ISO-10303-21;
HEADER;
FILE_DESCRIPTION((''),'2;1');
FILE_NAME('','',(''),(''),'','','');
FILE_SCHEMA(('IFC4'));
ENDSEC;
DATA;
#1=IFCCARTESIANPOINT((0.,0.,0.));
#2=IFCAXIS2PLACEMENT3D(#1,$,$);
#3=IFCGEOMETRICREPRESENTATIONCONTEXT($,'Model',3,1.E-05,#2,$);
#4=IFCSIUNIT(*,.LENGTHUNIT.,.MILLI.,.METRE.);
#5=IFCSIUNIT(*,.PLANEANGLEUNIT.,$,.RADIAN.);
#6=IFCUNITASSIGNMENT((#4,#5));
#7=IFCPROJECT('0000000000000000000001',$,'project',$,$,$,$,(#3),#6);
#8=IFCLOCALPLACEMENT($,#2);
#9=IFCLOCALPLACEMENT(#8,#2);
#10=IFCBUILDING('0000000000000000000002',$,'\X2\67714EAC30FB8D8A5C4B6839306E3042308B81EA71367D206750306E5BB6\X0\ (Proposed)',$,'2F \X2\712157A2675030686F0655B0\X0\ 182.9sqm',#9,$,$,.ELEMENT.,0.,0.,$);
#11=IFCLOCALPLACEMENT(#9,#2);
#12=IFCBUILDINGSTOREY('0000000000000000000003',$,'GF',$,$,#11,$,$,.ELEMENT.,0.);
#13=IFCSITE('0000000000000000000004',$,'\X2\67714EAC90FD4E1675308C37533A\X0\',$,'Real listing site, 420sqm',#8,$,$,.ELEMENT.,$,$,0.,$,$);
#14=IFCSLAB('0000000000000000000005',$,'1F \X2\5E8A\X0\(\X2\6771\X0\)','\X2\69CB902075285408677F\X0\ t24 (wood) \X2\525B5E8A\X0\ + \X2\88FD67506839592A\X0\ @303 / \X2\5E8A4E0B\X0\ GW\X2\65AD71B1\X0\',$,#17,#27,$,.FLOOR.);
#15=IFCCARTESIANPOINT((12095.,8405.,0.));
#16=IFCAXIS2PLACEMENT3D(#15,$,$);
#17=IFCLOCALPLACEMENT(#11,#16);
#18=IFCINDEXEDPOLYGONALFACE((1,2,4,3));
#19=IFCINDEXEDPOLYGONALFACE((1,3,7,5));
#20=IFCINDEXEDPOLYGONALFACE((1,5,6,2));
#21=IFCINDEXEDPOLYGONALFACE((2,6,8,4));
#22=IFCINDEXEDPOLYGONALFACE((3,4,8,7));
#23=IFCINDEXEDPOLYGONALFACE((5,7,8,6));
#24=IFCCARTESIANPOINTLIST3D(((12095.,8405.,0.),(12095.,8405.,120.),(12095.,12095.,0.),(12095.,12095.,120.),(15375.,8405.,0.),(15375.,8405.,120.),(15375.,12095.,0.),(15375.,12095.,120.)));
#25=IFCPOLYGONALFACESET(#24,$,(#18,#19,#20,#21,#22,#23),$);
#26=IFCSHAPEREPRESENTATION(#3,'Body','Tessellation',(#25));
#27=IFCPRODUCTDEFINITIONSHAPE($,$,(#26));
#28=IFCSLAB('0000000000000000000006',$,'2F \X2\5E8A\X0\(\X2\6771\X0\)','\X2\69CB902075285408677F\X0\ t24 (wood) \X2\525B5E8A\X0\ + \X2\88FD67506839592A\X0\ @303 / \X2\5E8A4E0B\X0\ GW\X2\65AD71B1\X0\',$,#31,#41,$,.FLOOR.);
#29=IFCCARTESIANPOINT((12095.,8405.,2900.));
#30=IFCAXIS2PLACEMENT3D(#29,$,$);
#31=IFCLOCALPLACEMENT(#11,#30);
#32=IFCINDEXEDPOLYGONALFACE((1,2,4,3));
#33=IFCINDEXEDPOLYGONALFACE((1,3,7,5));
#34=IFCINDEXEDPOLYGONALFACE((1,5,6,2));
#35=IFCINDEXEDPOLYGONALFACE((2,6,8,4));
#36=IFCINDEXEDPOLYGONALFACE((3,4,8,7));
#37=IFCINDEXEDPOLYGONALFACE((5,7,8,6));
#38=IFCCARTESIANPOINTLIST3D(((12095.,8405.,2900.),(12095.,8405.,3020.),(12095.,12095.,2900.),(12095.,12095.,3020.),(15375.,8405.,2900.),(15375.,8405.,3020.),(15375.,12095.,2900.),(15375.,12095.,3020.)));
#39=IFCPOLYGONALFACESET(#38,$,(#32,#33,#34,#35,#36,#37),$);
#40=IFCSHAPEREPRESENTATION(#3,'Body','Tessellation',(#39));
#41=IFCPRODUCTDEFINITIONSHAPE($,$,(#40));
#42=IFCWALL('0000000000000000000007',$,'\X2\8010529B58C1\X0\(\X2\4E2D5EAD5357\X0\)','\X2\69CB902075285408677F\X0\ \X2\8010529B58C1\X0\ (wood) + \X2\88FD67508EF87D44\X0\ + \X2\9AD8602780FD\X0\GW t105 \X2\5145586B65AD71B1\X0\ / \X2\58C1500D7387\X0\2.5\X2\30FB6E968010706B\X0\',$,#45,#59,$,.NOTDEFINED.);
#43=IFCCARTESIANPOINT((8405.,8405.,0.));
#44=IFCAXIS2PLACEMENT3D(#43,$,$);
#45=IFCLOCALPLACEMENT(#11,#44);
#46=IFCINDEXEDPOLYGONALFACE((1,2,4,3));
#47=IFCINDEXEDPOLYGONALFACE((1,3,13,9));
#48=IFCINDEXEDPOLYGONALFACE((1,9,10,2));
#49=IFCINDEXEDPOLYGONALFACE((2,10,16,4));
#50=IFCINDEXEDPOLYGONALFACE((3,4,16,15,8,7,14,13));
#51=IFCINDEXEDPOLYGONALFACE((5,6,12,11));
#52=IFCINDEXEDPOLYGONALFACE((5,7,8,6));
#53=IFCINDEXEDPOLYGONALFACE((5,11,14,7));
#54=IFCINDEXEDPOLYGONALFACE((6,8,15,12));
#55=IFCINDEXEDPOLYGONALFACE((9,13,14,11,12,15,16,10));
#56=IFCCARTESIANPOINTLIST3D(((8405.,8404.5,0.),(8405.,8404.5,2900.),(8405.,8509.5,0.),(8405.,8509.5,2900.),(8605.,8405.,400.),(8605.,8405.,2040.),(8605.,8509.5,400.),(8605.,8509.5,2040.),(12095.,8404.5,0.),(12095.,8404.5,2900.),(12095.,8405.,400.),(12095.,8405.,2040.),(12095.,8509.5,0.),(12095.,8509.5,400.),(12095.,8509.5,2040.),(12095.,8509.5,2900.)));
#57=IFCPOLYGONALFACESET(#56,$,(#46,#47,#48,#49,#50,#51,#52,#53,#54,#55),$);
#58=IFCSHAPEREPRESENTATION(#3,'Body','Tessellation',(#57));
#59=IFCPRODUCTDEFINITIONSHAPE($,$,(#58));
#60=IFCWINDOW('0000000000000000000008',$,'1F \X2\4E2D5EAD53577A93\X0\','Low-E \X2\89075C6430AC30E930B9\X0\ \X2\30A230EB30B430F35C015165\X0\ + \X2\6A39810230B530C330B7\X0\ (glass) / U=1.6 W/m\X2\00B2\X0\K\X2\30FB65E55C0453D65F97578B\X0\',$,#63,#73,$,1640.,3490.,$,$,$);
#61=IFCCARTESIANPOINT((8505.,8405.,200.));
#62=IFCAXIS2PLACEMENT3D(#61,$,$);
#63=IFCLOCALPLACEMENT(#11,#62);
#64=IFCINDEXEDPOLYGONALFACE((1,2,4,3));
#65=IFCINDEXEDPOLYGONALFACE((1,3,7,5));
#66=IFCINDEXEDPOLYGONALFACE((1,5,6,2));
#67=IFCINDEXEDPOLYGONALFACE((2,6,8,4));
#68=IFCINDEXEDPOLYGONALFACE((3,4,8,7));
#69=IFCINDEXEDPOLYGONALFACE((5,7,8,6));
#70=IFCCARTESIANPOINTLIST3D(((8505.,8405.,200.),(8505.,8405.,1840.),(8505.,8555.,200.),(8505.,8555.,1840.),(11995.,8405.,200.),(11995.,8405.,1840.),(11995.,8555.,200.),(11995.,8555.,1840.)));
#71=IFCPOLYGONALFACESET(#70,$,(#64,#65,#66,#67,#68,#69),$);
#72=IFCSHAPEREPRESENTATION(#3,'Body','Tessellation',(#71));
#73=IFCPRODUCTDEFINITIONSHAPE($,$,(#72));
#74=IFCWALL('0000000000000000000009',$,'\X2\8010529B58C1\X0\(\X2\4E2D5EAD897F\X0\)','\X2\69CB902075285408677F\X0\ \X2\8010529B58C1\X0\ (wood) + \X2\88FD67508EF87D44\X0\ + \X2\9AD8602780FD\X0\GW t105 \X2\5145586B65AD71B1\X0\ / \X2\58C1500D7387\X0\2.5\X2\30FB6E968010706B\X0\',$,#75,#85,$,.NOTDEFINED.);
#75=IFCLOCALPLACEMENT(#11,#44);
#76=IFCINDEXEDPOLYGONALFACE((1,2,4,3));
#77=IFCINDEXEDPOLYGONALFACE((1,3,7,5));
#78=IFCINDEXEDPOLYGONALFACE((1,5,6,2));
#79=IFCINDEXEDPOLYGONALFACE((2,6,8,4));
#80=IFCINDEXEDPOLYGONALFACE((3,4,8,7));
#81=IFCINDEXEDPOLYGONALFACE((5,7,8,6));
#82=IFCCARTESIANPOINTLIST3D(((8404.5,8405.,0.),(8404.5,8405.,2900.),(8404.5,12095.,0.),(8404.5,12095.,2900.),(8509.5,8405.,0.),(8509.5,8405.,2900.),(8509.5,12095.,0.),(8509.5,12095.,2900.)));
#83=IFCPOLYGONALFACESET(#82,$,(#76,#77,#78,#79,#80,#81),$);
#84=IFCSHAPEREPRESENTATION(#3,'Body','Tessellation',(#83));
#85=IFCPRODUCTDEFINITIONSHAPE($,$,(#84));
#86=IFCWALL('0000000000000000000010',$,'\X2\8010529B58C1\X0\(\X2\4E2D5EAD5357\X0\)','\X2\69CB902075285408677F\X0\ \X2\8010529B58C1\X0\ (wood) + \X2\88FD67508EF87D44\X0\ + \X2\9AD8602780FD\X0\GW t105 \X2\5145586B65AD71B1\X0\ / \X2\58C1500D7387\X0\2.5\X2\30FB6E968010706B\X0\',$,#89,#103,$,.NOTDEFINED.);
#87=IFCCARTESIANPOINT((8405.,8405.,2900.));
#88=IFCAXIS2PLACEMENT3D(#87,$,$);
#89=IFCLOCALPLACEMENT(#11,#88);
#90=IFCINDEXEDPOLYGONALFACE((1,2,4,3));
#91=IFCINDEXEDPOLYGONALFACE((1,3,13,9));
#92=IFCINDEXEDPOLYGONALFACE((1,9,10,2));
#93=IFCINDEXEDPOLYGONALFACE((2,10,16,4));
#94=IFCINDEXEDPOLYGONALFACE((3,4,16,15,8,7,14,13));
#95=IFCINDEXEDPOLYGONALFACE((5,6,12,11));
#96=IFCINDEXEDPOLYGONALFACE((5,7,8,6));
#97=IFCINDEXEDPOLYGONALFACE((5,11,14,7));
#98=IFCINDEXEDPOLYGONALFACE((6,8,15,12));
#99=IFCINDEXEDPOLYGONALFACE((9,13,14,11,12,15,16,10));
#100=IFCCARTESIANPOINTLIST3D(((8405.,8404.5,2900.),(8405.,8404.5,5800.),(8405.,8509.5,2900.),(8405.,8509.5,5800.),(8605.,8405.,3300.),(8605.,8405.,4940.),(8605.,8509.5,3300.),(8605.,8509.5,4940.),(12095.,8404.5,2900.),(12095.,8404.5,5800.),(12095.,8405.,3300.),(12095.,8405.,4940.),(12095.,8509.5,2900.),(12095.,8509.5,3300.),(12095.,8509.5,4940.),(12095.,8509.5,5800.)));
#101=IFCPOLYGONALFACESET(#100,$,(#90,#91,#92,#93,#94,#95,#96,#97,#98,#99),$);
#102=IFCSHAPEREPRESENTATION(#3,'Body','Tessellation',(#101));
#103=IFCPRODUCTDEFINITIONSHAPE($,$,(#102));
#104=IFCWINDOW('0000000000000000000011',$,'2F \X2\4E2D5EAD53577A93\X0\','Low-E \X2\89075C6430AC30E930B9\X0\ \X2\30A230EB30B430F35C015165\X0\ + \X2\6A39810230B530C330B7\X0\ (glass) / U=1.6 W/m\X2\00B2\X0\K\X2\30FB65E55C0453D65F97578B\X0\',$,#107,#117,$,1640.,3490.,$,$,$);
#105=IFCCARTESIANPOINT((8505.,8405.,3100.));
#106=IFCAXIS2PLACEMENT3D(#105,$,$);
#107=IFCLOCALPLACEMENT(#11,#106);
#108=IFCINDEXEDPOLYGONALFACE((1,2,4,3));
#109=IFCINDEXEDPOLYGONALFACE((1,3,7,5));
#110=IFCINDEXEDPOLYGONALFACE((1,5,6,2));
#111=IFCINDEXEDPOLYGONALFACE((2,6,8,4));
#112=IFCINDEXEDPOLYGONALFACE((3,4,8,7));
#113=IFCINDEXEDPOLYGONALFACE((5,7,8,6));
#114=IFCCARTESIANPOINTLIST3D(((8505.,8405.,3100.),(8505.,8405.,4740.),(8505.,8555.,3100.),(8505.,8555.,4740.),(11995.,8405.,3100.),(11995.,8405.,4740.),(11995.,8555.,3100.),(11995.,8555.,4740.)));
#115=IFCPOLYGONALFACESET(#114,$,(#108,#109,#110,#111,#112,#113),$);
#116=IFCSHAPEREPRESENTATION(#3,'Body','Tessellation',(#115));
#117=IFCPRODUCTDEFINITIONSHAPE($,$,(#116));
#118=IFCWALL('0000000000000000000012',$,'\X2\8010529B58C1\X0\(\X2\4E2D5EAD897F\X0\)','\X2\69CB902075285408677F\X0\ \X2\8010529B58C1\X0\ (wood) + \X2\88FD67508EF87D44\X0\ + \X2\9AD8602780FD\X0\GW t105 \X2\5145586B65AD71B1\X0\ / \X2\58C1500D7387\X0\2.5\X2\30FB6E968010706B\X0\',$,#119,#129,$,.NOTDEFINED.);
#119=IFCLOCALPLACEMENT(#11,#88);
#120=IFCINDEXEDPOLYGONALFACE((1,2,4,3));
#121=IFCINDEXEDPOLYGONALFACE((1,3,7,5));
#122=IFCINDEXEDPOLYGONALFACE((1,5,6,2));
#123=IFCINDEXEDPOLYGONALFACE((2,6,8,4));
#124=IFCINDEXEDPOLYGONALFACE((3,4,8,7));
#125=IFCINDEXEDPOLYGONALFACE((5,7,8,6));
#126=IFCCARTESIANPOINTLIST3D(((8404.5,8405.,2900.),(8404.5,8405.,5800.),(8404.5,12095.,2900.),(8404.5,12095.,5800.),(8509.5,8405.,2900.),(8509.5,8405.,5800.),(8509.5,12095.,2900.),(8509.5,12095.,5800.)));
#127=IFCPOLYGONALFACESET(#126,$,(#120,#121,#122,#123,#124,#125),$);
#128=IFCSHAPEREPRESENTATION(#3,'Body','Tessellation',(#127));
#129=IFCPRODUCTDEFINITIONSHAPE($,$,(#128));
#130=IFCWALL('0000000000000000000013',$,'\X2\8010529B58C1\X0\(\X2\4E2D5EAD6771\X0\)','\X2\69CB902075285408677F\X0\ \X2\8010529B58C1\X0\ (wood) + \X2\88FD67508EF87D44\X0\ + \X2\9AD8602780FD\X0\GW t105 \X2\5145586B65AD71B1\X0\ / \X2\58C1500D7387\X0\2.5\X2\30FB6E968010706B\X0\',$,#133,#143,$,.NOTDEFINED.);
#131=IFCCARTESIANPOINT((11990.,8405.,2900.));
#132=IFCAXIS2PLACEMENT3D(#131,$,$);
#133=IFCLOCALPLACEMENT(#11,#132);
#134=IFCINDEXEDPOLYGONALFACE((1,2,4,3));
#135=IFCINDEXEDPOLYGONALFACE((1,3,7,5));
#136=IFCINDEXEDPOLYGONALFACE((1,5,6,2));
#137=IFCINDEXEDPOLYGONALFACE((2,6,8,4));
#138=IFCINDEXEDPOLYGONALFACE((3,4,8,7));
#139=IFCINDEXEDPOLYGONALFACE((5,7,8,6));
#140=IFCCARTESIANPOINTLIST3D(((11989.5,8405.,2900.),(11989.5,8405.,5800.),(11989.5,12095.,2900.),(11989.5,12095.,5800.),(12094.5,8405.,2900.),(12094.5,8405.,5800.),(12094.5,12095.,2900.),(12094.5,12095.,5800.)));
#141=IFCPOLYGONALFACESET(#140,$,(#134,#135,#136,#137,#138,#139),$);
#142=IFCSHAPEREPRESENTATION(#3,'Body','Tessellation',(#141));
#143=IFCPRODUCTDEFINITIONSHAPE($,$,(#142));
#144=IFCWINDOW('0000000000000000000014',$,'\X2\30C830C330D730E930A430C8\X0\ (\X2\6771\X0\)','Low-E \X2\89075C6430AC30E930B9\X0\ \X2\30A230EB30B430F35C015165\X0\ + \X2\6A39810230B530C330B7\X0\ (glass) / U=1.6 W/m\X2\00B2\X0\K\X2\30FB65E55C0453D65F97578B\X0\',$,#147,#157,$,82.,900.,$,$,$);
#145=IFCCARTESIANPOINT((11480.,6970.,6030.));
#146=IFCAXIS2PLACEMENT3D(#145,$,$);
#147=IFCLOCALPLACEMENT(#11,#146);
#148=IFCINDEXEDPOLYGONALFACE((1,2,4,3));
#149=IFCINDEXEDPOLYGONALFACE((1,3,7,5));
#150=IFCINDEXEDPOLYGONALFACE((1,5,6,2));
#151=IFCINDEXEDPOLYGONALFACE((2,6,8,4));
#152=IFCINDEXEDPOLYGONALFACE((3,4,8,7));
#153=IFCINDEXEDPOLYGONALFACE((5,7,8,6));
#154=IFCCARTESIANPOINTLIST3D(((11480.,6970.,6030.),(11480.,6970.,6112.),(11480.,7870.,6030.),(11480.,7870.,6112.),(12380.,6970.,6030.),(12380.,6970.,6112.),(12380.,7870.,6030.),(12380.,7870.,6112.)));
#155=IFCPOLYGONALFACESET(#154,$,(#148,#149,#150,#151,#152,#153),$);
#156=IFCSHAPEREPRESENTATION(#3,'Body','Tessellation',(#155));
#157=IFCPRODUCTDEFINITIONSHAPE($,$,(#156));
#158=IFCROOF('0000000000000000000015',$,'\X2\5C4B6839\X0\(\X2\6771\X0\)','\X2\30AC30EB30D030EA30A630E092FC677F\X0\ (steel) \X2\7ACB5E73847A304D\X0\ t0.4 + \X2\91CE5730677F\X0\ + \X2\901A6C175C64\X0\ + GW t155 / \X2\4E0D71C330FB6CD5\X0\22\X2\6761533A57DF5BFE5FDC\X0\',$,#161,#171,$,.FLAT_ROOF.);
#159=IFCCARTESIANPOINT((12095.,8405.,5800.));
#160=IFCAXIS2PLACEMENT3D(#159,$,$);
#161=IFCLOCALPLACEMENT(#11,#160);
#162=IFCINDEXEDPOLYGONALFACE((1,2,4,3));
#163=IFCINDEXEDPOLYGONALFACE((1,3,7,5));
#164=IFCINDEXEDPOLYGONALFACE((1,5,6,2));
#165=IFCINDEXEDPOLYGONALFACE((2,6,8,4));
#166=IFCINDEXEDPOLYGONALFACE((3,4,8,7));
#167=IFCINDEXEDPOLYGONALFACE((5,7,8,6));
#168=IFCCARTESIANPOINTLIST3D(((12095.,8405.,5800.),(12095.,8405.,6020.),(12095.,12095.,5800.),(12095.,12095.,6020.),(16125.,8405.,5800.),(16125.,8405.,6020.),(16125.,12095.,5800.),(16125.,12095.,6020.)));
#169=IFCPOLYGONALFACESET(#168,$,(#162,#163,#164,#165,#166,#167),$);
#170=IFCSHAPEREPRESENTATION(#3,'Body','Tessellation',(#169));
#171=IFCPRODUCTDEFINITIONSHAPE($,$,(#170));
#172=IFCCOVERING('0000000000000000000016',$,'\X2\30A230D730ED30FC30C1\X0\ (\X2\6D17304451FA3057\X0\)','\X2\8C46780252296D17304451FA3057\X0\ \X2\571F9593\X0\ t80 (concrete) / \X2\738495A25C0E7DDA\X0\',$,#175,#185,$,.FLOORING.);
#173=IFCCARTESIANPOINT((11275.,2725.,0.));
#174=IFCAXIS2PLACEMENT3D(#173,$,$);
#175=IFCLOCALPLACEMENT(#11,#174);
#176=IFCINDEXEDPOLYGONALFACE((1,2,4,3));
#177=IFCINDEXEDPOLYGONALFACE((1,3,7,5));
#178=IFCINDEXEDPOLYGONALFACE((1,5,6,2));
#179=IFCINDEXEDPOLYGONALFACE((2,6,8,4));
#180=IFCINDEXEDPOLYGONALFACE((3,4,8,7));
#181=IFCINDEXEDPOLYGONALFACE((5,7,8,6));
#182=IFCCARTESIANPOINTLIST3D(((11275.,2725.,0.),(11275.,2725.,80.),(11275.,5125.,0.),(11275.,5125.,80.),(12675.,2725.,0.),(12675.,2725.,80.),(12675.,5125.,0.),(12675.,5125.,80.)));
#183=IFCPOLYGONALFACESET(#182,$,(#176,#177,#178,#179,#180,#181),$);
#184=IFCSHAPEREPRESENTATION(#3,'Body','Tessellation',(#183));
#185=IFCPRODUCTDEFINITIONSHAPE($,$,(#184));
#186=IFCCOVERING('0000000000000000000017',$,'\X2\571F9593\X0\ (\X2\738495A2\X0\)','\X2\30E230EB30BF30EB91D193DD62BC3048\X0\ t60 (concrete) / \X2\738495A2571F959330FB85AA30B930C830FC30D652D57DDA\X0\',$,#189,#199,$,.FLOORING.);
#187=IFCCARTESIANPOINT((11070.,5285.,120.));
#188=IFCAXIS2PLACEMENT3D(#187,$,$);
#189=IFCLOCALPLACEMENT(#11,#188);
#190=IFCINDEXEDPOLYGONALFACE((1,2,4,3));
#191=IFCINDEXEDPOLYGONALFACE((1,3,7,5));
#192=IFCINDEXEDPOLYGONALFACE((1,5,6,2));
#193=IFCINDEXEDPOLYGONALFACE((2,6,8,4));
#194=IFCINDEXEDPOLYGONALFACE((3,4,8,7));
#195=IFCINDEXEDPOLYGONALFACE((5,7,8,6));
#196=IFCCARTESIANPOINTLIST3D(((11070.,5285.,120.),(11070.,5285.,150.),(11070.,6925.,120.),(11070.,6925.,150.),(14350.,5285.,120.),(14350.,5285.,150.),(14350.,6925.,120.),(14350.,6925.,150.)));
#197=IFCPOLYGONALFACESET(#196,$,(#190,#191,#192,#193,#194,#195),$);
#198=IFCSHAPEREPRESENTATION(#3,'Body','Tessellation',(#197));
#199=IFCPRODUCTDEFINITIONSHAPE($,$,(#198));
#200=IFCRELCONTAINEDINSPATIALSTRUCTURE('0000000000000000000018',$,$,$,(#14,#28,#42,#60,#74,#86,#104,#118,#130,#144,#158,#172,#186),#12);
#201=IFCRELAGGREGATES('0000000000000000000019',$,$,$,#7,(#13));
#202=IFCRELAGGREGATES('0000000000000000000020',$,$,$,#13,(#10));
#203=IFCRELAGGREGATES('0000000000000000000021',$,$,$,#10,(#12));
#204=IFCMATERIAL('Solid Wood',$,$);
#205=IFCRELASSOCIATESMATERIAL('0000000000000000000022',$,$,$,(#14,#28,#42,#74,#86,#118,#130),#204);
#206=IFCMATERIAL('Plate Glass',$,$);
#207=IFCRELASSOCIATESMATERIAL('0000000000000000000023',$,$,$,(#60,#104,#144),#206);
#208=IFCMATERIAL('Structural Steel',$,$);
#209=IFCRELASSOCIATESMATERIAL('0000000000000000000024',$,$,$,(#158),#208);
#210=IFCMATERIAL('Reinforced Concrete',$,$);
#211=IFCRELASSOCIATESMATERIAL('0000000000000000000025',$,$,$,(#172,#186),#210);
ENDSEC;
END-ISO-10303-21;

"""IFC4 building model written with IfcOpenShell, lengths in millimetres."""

from ifc_helpers import new_model, si_unit, frame, frame_2d, origin, place, context, project, spatial, rectangle, extrude, material, element, fill, save


model = new_model("IFC4")

# Units and contexts
model_context = context("Model", 3, precision=1e-05, world=origin())
ifc_project = project(units=[si_unit("LENGTHUNIT", "METRE", prefix="MILLI"), si_unit("PLANEANGLEUNIT", "RADIAN")], contexts=[model_context])

# Site, building, storey
site_placement = place(None, origin())
site = spatial("IfcSite", under=ifc_project, at=site_placement, Name="東京都世田谷区", ObjectType="Real listing site, 420sqm", CompositionType="ELEMENT", RefElevation=0.0)
building_placement = place(site_placement, origin())
building = spatial("IfcBuilding", under=site, at=building_placement, Name="東京・越屋根のある自然素材の家 (Proposed)", ObjectType="2F 無垢材と漆喰 182.9sqm", CompositionType="ELEMENT", ElevationOfRefHeight=0.0, ElevationOfTerrain=0.0)
storey_placement = place(building_placement, origin())
storey = spatial("IfcBuildingStorey", under=building, at=storey_placement, Name="GF", CompositionType="ELEMENT", Elevation=0.0)

# Shared definitions
ifc_material_1 = material(Name="Solid Wood")

# Slabs
slab_1_placement = place(storey_placement, frame((12095.0, 8405.0, 0.0)))
element("IfcSlab", 1, at=slab_1_placement, inside=storey, material=ifc_material_1, Name="1F 床(東)", Description="構造用合板 t24 (wood) 剛床 + 製材根太 @303 / 床下 GW断熱", PredefinedType="FLOOR", context=model_context, shape_type="SweptSolid", body=[
    extrude(rectangle(XDim=3280.0, YDim=3690.0, at=frame_2d((1640.0, 1845.0))), frame((12095.0, 8405.0, 0.0)), (0.0, 0.0, 1.0), 120.0),
])
slab_2_placement = place(storey_placement, frame((12095.0, 8405.0, 2900.0)))
element("IfcSlab", 2, at=slab_2_placement, inside=storey, material=ifc_material_1, Name="2F 床(東)", Description="構造用合板 t24 (wood) 剛床 + 製材根太 @303 / 床下 GW断熱", PredefinedType="FLOOR", context=model_context, shape_type="SweptSolid", body=[
    extrude(rectangle(XDim=3280.0, YDim=3690.0, at=frame_2d((1640.0, 1845.0))), frame((12095.0, 8405.0, 2900.0)), (0.0, 0.0, 1.0), 120.0),
])

# Wall, opening, window
wall_1_placement = place(storey_placement, frame((8405.0, 8405.0, 0.0)))
wall_1 = element("IfcWall", 3, at=wall_1_placement, inside=storey, material=ifc_material_1, Name="耐力壁(中庭南)", Description="構造用合板 耐力壁 (wood) + 製材軸組 + 高性能GW t105 充填断熱 / 壁倍率2.5・準耐火", PredefinedType="NOTDEFINED", context=model_context, shape_type="SweptSolid", body=[
    extrude(rectangle(XDim=3690.0, YDim=105.0, at=frame_2d((1845.0, 52.0))), frame((8405.0, 8405.0, 0.0)), (0.0, 0.0, 1.0), 2900.0),
])
opening_1_placement = place(storey_placement, frame((8505.0, 8405.0, 200.0)))
opening_1 = element("IfcOpeningElement", 4, at=opening_1_placement, cuts=wall_1, PredefinedType="NOTDEFINED", context=model_context, shape_type="SweptSolid", body=[
    extrude(rectangle(XDim=3490.0, YDim=150.0, at=frame_2d((1745.0, 75.0))), frame((8505.0, 8405.0, 200.0)), (0.0, 0.0, 1.0), 1640.0),
])
ifc_material_2 = material(Name="Plate Glass")
window_1_placement = place(storey_placement, frame((8505.0, 8405.0, 200.0)))
window_1 = element("IfcWindow", 5, at=window_1_placement, inside=storey, material=ifc_material_2, Name="1F 中庭南窓", Description="Low-E 複層ガラス アルゴン封入 + 樹脂サッシ (glass) / U=1.6 W/m²K・日射取得型", OverallHeight=1640.0, OverallWidth=3490.0, context=model_context, shape_type="SweptSolid", body=[
    extrude(rectangle(XDim=3490.0, YDim=150.0, at=frame_2d((1745.0, 75.0))), frame((8505.0, 8405.0, 200.0)), (0.0, 0.0, 1.0), 1640.0),
])
fill(opening_1, window_1)

# Wall
wall_2_placement = place(storey_placement, frame((8405.0, 8405.0, 0.0)))
element("IfcWall", 6, at=wall_2_placement, inside=storey, material=ifc_material_1, Name="耐力壁(中庭西)", Description="構造用合板 耐力壁 (wood) + 製材軸組 + 高性能GW t105 充填断熱 / 壁倍率2.5・準耐火", PredefinedType="NOTDEFINED", context=model_context, shape_type="SweptSolid", body=[
    extrude(rectangle(XDim=105.0, YDim=3690.0, at=frame_2d((52.0, 1845.0))), frame((8405.0, 8405.0, 0.0)), (0.0, 0.0, 1.0), 2900.0),
])

# Wall, opening, window
wall_3_placement = place(storey_placement, frame((8405.0, 8405.0, 2900.0)))
wall_3 = element("IfcWall", 7, at=wall_3_placement, inside=storey, material=ifc_material_1, Name="耐力壁(中庭南)", Description="構造用合板 耐力壁 (wood) + 製材軸組 + 高性能GW t105 充填断熱 / 壁倍率2.5・準耐火", PredefinedType="NOTDEFINED", context=model_context, shape_type="SweptSolid", body=[
    extrude(rectangle(XDim=3690.0, YDim=105.0, at=frame_2d((1845.0, 52.0))), frame((8405.0, 8405.0, 2900.0)), (0.0, 0.0, 1.0), 2900.0),
])
opening_2_placement = place(storey_placement, frame((8505.0, 8405.0, 3100.0)))
opening_2 = element("IfcOpeningElement", 8, at=opening_2_placement, cuts=wall_3, PredefinedType="NOTDEFINED", context=model_context, shape_type="SweptSolid", body=[
    extrude(rectangle(XDim=3490.0, YDim=150.0, at=frame_2d((1745.0, 75.0))), frame((8505.0, 8405.0, 3100.0)), (0.0, 0.0, 1.0), 1640.0),
])
window_2_placement = place(storey_placement, frame((8505.0, 8405.0, 3100.0)))
window_2 = element("IfcWindow", 9, at=window_2_placement, inside=storey, material=ifc_material_2, Name="2F 中庭南窓", Description="Low-E 複層ガラス アルゴン封入 + 樹脂サッシ (glass) / U=1.6 W/m²K・日射取得型", OverallHeight=1640.0, OverallWidth=3490.0, context=model_context, shape_type="SweptSolid", body=[
    extrude(rectangle(XDim=3490.0, YDim=150.0, at=frame_2d((1745.0, 75.0))), frame((8505.0, 8405.0, 3100.0)), (0.0, 0.0, 1.0), 1640.0),
])
fill(opening_2, window_2)

# Walls
wall_4_placement = place(storey_placement, frame((8405.0, 8405.0, 2900.0)))
element("IfcWall", 10, at=wall_4_placement, inside=storey, material=ifc_material_1, Name="耐力壁(中庭西)", Description="構造用合板 耐力壁 (wood) + 製材軸組 + 高性能GW t105 充填断熱 / 壁倍率2.5・準耐火", PredefinedType="NOTDEFINED", context=model_context, shape_type="SweptSolid", body=[
    extrude(rectangle(XDim=105.0, YDim=3690.0, at=frame_2d((52.0, 1845.0))), frame((8405.0, 8405.0, 2900.0)), (0.0, 0.0, 1.0), 2900.0),
])
wall_5_placement = place(storey_placement, frame((11990.0, 8405.0, 2900.0)))
element("IfcWall", 11, at=wall_5_placement, inside=storey, material=ifc_material_1, Name="耐力壁(中庭東)", Description="構造用合板 耐力壁 (wood) + 製材軸組 + 高性能GW t105 充填断熱 / 壁倍率2.5・準耐火", PredefinedType="NOTDEFINED", context=model_context, shape_type="SweptSolid", body=[
    extrude(rectangle(XDim=105.0, YDim=3690.0, at=frame_2d((52.0, 1845.0))), frame((11990.0, 8405.0, 2900.0)), (0.0, 0.0, 1.0), 2900.0),
])

# Window
window_3_placement = place(storey_placement, frame((11480.0, 6970.0, 6030.0)))
element("IfcWindow", 12, at=window_3_placement, inside=storey, material=ifc_material_2, Name="トップライト (東)", Description="Low-E 複層ガラス アルゴン封入 + 樹脂サッシ (glass) / U=1.6 W/m²K・日射取得型", OverallHeight=82.0, OverallWidth=900.0, context=model_context, shape_type="SweptSolid", body=[
    extrude(rectangle(XDim=900.0, YDim=900.0, at=frame_2d((450.0, 450.0))), frame((11480.0, 6970.0, 6030.0)), (0.0, 0.0, 1.0), 82.0),
])

# Roof
ifc_material_3 = material(Name="Structural Steel")
roof_placement = place(storey_placement, frame((12095.0, 8405.0, 5800.0)))
element("IfcRoof", 13, at=roof_placement, inside=storey, material=ifc_material_3, Name="屋根(東)", Description="ガルバリウム鋼板 (steel) 立平葺き t0.4 + 野地板 + 通気層 + GW t155 / 不燃・法22条区域対応", PredefinedType="FLAT_ROOF", context=model_context, shape_type="SweptSolid", body=[
    extrude(rectangle(XDim=4030.0, YDim=3690.0, at=frame_2d((2015.0, 1845.0))), frame((12095.0, 8405.0, 5800.0)), (0.0, 0.0, 1.0), 220.0),
])

# Coverings
ifc_material_4 = material(Name="Reinforced Concrete")
covering_1_placement = place(storey_placement, frame((11275.0, 2725.0, 0.0)))
element("IfcCovering", 14, at=covering_1_placement, inside=storey, material=ifc_material_4, Name="アプローチ (洗い出し)", Description="豆砂利洗い出し 土間 t80 (concrete) / 玄関導線", PredefinedType="FLOORING", context=model_context, shape_type="SweptSolid", body=[
    extrude(rectangle(XDim=1400.0, YDim=2400.0, at=frame_2d((700.0, 1200.0))), frame((11275.0, 2725.0, 0.0)), (0.0, 0.0, 1.0), 80.0),
])
covering_2_placement = place(storey_placement, frame((11070.0, 5285.0, 120.0)))
element("IfcCovering", 15, at=covering_2_placement, inside=storey, material=ifc_material_4, Name="土間 (玄関)", Description="モルタル金鏝押え t60 (concrete) / 玄関土間・薪ストーブ動線", PredefinedType="FLOORING", context=model_context, shape_type="SweptSolid", body=[
    extrude(rectangle(XDim=3280.0, YDim=1640.0, at=frame_2d((1640.0, 820.0))), frame((11070.0, 5285.0, 120.0)), (0.0, 0.0, 1.0), 30.0),
])

save(model, "model.ifc")
